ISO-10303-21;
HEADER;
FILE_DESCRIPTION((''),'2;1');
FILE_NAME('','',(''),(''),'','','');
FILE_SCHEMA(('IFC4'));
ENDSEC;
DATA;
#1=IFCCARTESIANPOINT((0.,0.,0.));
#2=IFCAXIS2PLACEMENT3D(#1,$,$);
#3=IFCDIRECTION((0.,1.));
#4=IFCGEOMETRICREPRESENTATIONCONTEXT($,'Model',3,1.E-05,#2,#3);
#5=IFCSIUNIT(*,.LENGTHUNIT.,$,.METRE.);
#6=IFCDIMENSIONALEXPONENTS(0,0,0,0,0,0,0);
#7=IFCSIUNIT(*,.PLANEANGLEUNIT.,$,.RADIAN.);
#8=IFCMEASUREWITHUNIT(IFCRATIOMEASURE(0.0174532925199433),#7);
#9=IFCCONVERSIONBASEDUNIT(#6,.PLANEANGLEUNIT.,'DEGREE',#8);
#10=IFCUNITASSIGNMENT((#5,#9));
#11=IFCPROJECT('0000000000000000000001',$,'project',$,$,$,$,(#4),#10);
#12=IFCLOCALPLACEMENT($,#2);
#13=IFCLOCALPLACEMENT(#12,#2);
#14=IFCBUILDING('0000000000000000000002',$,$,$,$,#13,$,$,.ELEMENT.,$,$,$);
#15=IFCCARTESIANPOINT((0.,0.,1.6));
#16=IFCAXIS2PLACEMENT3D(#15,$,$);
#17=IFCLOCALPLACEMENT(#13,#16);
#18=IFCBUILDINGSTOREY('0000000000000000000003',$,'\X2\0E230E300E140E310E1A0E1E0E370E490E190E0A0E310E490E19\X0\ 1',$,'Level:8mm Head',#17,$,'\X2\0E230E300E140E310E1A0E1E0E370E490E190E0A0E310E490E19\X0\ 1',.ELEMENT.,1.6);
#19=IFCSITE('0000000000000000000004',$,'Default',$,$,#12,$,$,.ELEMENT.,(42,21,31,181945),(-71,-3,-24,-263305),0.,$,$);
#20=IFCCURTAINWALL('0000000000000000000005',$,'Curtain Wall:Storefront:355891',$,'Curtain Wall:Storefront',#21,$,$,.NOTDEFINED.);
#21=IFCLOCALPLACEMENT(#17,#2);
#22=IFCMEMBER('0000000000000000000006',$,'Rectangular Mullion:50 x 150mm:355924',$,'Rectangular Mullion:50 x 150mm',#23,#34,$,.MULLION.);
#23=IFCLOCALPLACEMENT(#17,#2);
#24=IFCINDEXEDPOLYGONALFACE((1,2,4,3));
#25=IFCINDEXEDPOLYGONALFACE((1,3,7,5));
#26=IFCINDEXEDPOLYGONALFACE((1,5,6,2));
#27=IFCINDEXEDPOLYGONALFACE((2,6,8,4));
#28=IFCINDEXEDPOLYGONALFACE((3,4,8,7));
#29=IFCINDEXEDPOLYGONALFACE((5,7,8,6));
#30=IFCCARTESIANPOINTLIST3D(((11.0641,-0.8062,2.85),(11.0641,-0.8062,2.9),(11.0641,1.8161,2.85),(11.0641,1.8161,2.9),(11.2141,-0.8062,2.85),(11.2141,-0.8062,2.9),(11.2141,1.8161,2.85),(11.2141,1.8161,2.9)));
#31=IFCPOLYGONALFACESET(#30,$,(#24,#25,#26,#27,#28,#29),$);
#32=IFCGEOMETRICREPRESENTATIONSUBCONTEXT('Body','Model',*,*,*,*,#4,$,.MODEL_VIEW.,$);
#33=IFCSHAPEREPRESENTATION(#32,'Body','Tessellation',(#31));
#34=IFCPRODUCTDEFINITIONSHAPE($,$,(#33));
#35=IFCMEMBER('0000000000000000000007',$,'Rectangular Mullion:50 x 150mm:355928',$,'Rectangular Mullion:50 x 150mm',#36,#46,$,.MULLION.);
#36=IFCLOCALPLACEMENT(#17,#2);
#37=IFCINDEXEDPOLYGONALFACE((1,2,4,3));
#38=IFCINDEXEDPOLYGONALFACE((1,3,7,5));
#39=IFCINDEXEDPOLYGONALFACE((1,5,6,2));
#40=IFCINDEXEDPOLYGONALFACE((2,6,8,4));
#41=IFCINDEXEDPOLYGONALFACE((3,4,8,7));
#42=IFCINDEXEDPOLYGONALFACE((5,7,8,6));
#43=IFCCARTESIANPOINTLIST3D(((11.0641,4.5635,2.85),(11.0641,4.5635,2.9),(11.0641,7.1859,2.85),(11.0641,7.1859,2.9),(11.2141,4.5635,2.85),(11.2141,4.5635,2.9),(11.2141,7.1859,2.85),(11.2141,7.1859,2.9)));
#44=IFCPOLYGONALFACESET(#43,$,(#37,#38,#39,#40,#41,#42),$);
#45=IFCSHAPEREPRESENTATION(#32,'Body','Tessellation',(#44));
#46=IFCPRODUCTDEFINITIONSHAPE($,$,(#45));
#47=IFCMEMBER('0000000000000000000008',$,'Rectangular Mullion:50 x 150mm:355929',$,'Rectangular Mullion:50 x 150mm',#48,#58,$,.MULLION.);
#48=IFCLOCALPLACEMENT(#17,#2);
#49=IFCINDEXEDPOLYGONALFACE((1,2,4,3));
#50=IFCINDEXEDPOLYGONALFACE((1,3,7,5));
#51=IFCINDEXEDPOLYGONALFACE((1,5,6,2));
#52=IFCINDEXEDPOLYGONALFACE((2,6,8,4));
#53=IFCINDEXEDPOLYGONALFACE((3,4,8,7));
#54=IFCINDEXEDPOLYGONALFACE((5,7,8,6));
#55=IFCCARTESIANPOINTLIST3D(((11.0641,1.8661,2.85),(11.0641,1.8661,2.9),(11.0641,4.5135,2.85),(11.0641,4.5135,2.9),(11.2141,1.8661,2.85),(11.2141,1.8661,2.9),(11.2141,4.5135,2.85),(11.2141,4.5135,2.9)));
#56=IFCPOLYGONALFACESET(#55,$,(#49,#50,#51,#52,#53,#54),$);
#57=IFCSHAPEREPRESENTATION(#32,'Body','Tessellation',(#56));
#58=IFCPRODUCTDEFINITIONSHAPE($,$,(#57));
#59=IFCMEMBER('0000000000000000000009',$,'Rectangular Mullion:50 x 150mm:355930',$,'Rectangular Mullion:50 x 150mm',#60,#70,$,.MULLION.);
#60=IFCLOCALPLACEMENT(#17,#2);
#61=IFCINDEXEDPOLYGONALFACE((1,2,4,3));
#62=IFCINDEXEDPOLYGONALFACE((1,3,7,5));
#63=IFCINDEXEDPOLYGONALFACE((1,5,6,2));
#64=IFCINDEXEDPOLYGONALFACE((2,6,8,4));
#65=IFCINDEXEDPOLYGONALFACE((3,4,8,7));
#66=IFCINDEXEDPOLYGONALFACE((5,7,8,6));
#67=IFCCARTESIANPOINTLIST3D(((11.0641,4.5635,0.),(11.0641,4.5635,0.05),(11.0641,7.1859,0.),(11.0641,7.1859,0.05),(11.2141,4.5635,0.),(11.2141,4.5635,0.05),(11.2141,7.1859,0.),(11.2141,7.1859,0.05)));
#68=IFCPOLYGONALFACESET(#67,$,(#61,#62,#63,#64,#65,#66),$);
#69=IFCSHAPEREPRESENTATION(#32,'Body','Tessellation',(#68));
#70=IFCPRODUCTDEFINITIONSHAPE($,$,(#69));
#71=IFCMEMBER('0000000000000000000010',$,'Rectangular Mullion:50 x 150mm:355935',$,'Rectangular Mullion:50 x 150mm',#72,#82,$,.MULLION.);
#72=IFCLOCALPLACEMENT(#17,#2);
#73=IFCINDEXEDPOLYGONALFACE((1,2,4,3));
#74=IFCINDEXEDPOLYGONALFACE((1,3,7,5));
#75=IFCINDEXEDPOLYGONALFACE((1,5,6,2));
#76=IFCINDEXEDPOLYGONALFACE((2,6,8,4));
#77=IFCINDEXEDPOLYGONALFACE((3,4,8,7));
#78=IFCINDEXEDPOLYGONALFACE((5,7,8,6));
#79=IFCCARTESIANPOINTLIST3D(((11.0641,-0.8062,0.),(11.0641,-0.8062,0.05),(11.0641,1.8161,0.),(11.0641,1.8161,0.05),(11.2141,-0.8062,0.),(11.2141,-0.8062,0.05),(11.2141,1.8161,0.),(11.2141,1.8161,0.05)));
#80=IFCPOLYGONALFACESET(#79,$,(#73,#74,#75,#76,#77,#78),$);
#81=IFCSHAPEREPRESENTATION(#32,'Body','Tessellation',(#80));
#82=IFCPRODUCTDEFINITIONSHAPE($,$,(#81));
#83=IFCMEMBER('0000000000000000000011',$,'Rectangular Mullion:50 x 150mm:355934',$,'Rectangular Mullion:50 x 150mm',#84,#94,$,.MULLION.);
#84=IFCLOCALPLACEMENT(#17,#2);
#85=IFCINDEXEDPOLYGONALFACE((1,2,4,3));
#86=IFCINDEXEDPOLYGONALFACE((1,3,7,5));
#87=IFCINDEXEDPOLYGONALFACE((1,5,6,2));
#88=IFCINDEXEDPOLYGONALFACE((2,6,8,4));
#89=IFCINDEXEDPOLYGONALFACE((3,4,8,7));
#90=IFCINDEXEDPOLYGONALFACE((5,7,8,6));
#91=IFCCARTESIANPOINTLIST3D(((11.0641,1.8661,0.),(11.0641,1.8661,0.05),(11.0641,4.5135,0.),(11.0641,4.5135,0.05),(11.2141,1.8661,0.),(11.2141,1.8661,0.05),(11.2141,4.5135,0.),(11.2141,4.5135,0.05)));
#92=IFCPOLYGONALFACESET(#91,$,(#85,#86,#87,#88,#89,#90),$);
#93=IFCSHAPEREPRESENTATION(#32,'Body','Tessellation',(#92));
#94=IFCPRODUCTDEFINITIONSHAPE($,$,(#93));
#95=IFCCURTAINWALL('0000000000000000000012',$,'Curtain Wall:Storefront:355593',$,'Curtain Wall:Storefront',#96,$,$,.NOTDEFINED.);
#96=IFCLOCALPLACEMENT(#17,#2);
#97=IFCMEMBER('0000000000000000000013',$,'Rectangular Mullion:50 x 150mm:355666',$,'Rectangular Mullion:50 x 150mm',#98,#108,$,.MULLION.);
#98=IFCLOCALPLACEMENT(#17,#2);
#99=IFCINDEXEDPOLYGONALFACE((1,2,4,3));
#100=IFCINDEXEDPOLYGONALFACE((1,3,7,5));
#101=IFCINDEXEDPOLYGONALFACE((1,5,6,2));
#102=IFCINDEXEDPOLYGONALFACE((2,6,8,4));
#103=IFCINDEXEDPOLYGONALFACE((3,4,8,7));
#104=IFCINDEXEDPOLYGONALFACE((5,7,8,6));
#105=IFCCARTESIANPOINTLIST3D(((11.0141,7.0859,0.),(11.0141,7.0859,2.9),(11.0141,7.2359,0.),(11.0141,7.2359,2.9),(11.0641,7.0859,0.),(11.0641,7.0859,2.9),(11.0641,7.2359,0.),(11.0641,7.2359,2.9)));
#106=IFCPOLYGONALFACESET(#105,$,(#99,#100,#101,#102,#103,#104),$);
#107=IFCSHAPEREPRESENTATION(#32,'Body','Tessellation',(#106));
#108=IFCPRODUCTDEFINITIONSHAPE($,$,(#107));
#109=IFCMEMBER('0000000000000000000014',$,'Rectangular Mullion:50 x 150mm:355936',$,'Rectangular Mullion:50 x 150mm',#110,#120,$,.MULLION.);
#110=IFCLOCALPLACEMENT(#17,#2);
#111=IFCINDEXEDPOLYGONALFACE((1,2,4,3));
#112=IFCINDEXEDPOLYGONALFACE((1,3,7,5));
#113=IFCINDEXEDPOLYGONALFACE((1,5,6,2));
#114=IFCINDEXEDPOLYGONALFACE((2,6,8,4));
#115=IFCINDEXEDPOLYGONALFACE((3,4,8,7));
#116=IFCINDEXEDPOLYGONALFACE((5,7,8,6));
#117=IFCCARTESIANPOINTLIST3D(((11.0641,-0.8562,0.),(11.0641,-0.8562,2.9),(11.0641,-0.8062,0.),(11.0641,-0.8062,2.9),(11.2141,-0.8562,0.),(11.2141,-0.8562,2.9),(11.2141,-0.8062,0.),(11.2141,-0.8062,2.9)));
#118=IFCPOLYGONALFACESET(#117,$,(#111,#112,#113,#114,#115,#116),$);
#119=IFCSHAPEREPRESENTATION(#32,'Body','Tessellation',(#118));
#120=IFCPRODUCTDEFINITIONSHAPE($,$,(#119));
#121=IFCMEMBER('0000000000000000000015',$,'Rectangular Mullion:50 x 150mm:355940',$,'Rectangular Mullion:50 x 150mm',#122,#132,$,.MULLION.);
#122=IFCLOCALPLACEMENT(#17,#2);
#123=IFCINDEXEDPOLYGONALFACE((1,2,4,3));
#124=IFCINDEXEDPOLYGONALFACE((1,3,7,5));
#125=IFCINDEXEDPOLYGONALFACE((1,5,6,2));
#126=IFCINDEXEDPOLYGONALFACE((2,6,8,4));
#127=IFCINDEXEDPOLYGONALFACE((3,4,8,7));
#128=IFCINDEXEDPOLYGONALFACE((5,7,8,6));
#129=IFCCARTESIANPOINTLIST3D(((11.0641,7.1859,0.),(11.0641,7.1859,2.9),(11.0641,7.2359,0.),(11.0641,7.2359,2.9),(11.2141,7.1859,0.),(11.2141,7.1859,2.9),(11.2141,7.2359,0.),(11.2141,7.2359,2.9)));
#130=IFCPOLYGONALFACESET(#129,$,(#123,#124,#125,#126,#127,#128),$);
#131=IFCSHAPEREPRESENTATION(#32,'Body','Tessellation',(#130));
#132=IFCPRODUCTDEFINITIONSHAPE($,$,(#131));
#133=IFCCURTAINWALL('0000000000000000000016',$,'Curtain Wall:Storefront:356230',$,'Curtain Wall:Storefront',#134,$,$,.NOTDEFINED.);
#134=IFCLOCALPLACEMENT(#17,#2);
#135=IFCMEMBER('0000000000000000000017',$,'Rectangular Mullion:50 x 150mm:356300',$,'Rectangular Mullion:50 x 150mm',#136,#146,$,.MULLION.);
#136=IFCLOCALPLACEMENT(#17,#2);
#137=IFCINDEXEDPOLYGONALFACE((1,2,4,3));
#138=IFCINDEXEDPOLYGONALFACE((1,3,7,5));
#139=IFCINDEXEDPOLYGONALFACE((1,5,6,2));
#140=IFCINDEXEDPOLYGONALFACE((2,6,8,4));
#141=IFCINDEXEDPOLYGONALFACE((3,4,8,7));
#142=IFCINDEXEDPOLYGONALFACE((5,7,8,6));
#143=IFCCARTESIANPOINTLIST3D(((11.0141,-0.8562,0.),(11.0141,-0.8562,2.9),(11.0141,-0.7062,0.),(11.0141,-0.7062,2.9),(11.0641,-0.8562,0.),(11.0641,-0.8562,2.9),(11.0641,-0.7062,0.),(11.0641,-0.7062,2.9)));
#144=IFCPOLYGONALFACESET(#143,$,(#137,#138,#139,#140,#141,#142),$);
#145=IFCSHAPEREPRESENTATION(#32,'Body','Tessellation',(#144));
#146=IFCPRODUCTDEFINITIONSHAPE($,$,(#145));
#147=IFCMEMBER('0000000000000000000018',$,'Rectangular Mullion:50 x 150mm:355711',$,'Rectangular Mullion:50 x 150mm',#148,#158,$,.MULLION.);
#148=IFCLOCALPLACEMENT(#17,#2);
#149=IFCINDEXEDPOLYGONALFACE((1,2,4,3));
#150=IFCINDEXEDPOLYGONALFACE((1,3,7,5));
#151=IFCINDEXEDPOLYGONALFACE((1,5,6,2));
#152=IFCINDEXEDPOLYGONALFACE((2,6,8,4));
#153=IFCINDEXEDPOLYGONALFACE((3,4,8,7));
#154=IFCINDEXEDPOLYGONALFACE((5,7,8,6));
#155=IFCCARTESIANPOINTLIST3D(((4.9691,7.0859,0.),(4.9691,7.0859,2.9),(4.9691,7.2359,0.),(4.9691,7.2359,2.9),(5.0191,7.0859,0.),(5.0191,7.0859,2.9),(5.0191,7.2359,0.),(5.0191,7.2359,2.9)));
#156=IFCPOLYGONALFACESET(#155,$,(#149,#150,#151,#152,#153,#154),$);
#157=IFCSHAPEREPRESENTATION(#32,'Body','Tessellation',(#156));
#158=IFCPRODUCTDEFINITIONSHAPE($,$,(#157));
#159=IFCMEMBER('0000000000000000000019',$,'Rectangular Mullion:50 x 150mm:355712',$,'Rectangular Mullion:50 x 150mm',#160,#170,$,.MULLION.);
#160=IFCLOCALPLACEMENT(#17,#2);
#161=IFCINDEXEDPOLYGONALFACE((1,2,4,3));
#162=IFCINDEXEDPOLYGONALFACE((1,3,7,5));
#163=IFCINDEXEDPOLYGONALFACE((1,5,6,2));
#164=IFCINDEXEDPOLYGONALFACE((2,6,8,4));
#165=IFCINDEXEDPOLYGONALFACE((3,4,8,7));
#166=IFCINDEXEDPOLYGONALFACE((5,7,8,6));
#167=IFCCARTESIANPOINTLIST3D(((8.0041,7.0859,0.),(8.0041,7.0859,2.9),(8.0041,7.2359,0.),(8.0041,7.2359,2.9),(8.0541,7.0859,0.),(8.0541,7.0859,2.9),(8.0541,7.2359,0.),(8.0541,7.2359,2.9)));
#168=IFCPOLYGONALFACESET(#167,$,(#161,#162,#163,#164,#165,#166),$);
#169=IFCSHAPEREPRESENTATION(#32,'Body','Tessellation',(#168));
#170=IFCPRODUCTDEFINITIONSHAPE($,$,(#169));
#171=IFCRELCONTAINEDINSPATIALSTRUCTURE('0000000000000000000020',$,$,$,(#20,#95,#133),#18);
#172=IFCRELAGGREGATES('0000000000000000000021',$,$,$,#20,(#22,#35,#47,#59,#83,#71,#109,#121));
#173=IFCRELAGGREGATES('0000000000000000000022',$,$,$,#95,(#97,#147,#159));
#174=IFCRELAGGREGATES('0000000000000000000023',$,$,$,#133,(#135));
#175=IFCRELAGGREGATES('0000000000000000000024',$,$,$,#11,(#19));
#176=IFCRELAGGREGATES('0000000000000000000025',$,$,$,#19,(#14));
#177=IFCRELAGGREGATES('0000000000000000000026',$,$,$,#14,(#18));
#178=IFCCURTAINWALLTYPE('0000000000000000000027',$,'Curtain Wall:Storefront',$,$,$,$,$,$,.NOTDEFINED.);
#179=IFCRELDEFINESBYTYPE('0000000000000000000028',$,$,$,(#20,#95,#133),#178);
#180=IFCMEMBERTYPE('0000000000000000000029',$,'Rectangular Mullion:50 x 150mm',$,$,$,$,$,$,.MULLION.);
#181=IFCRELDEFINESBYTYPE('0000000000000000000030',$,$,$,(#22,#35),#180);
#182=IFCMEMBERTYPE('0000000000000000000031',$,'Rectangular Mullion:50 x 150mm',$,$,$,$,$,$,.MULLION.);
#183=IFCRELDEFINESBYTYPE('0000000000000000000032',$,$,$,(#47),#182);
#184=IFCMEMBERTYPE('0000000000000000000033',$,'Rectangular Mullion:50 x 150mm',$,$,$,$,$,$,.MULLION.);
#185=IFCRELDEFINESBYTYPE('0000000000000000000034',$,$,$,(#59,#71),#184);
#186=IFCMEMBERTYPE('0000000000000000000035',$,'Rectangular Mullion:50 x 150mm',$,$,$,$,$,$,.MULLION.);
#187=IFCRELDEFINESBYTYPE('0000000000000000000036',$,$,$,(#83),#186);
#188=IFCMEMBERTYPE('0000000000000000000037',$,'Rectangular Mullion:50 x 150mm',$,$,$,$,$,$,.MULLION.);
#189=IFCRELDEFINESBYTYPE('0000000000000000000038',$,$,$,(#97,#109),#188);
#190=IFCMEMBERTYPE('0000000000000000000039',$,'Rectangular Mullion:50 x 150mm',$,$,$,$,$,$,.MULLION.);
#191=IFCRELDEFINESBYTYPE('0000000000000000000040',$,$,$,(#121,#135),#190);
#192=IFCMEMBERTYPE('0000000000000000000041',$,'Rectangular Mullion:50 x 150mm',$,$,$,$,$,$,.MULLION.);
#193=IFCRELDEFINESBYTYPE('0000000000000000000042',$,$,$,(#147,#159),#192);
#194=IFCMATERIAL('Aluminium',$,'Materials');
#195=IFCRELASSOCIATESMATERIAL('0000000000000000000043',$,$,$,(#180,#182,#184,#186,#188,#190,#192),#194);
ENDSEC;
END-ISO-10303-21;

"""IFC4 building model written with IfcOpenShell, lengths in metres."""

from ifc_helpers import new_model, entity, si_unit, converted_unit, direction, frame, origin, place, context, subcontext, project, spatial, indexed_curve, outline, extrude, source, transform, mapped, material, type_object, type_shapes, element, aggregate, save


model = new_model("IFC4")

# Units and contexts
model_context = context("Model", 3, precision=1e-05, world=origin(), true_north=direction((0.0, 1.0)))
body_context = subcontext(model_context, "Body", "Model", "MODEL_VIEW")
ifc_project = project(units=[si_unit("LENGTHUNIT", "METRE"), converted_unit("PLANEANGLEUNIT", "DEGREE", entity("IfcRatioMeasure", 0.0174532925199433), si_unit("PLANEANGLEUNIT", "RADIAN"), dimensions=[0, 0, 0, 0, 0, 0, 0])], contexts=[model_context])

# Site, building, storey
site_placement = place(None, origin())
site = spatial("IfcSite", under=ifc_project, at=site_placement, Name="Default", CompositionType="ELEMENT", RefLatitude=(42, 21, 31, 181945), RefLongitude=(-71, -3, -24, -263305), RefElevation=0.0)
building_placement = place(site_placement, origin())
building = spatial("IfcBuilding", under=site, at=building_placement, CompositionType="ELEMENT")
storey_placement = place(building_placement, frame((0.0, 0.0, 1.6)))
storey = spatial("IfcBuildingStorey", under=building, at=storey_placement, Name="ระดับพื้นชั้น 1", ObjectType="Level:8mm Head", LongName="ระดับพื้นชั้น 1", CompositionType="ELEMENT", Elevation=1.6)

# Curtain wall, members
curtain_wall_type = type_object("IfcCurtainWallType", Name="Curtain Wall:Storefront", PredefinedType="NOTDEFINED")
curtain_wall_1_placement = place(storey_placement, frame((0.0, 0.0, -1.6)))
curtain_wall_1 = element("IfcCurtainWall", 1, at=curtain_wall_1_placement, inside=storey, type_object=curtain_wall_type, Name="Curtain Wall:Storefront:355891", ObjectType="Curtain Wall:Storefront", PredefinedType="NOTDEFINED")
ifc_material_1 = material(Name="Aluminium", Category="Materials")
member_type_1 = type_object("IfcMemberType", Name="Rectangular Mullion:50 x 150mm", PredefinedType="MULLION", material=ifc_material_1)
shared_shape_1 = source(origin(), body_context, "Body", "SweptSolid", [
    extrude(outline(indexed_curve([(-0.075, -0.025), (0.075, -0.025), (0.075, 0.025), (-0.075, 0.025), (-0.075, -0.025)], self_intersect=False)), frame((-0.025, 0.0, -2.6224), z_axis=(0.0, 0.0, 1.0), x_axis=(0.0, -1.0, 0.0)), (0.0, 0.0, 1.0), 2.6224),
])
type_shapes(member_type_1, [shared_shape_1])
member_1_placement = place(curtain_wall_1_placement, frame((11.1391, -0.8062, 4.5), z_axis=(0.0, -1.0, 0.0), x_axis=(0.0, 0.0, 1.0)))
member_1 = element("IfcMember", 2, at=member_1_placement, type_object=member_type_1, Name="Rectangular Mullion:50 x 150mm:355924", ObjectType="Rectangular Mullion:50 x 150mm", PredefinedType="MULLION", context=body_context, shape_type="MappedRepresentation", body=[
    mapped(shared_shape_1, transform((0.0, 0.0, 0.0), scale=1.0)),
])
member_2_placement = place(curtain_wall_1_placement, frame((11.1391, 4.5635, 4.5), z_axis=(0.0, -1.0, 0.0), x_axis=(0.0, 0.0, 1.0)))
member_2 = element("IfcMember", 3, at=member_2_placement, type_object=member_type_1, Name="Rectangular Mullion:50 x 150mm:355928", ObjectType="Rectangular Mullion:50 x 150mm", PredefinedType="MULLION", context=body_context, shape_type="MappedRepresentation", body=[
    mapped(shared_shape_1, transform((0.0, 0.0, 0.0), scale=1.0)),
])
member_type_2 = type_object("IfcMemberType", Name="Rectangular Mullion:50 x 150mm", PredefinedType="MULLION", material=ifc_material_1)
shared_shape_2 = source(origin(), body_context, "Body", "SweptSolid", [
    extrude(outline(indexed_curve([(-0.075, -0.025), (0.075, -0.025), (0.075, 0.025), (-0.075, 0.025), (-0.075, -0.025)], self_intersect=False)), frame((-0.025, 0.0, -2.6474), z_axis=(0.0, 0.0, 1.0), x_axis=(0.0, -1.0, 0.0)), (0.0, 0.0, 1.0), 2.6474),
])
type_shapes(member_type_2, [shared_shape_2])
member_3_placement = place(curtain_wall_1_placement, frame((11.1391, 1.8661, 4.5), z_axis=(0.0, -1.0, 0.0), x_axis=(0.0, 0.0, 1.0)))
member_3 = element("IfcMember", 4, at=member_3_placement, type_object=member_type_2, Name="Rectangular Mullion:50 x 150mm:355929", ObjectType="Rectangular Mullion:50 x 150mm", PredefinedType="MULLION", context=body_context, shape_type="MappedRepresentation", body=[
    mapped(shared_shape_2, transform((0.0, 0.0, 0.0), scale=1.0)),
])
member_type_3 = type_object("IfcMemberType", Name="Rectangular Mullion:50 x 150mm", PredefinedType="MULLION", material=ifc_material_1)
shared_shape_3 = source(origin(), body_context, "Body", "SweptSolid", [
    extrude(outline(indexed_curve([(-0.075, -0.025), (0.075, -0.025), (0.075, 0.025), (-0.075, 0.025), (-0.075, -0.025)], self_intersect=False)), frame((-0.025, 0.0, -2.6224), z_axis=(0.0, 0.0, 1.0), x_axis=(0.0, -1.0, 0.0)), (0.0, 0.0, 1.0), 2.6224),
])
type_shapes(member_type_3, [shared_shape_3])
member_4_placement = place(curtain_wall_1_placement, frame((11.1391, 7.1859, 1.6), z_axis=(0.0, 1.0, 0.0), x_axis=(0.0, 0.0, -1.0)))
member_4 = element("IfcMember", 5, at=member_4_placement, type_object=member_type_3, Name="Rectangular Mullion:50 x 150mm:355930", ObjectType="Rectangular Mullion:50 x 150mm", PredefinedType="MULLION", context=body_context, shape_type="MappedRepresentation", body=[
    mapped(shared_shape_3, transform((0.0, 0.0, 0.0), scale=1.0)),
])
member_5_placement = place(curtain_wall_1_placement, frame((11.1391, 1.8161, 1.6), z_axis=(0.0, 1.0, 0.0), x_axis=(0.0, 0.0, -1.0)))
member_5 = element("IfcMember", 6, at=member_5_placement, type_object=member_type_3, Name="Rectangular Mullion:50 x 150mm:355935", ObjectType="Rectangular Mullion:50 x 150mm", PredefinedType="MULLION", context=body_context, shape_type="MappedRepresentation", body=[
    mapped(shared_shape_3, transform((0.0, 0.0, 0.0), scale=1.0)),
])
member_type_4 = type_object("IfcMemberType", Name="Rectangular Mullion:50 x 150mm", PredefinedType="MULLION", material=ifc_material_1)
shared_shape_4 = source(origin(), body_context, "Body", "SweptSolid", [
    extrude(outline(indexed_curve([(-0.075, -0.025), (0.075, -0.025), (0.075, 0.025), (-0.075, 0.025), (-0.075, -0.025)], self_intersect=False)), frame((-0.025, 0.0, -2.6474), z_axis=(0.0, 0.0, 1.0), x_axis=(0.0, -1.0, 0.0)), (0.0, 0.0, 1.0), 2.6474),
])
type_shapes(member_type_4, [shared_shape_4])
member_6_placement = place(curtain_wall_1_placement, frame((11.1391, 4.5135, 1.6), z_axis=(0.0, 1.0, 0.0), x_axis=(0.0, 0.0, -1.0)))
member_6 = element("IfcMember", 7, at=member_6_placement, type_object=member_type_4, Name="Rectangular Mullion:50 x 150mm:355934", ObjectType="Rectangular Mullion:50 x 150mm", PredefinedType="MULLION", context=body_context, shape_type="MappedRepresentation", body=[
    mapped(shared_shape_4, transform((0.0, 0.0, 0.0), scale=1.0)),
])

# Curtain wall, member
curtain_wall_2_placement = place(storey_placement, frame((0.0, 0.0, -1.6)))
curtain_wall_2 = element("IfcCurtainWall", 8, at=curtain_wall_2_placement, inside=storey, type_object=curtain_wall_type, Name="Curtain Wall:Storefront:355593", ObjectType="Curtain Wall:Storefront", PredefinedType="NOTDEFINED")
member_type_5 = type_object("IfcMemberType", Name="Rectangular Mullion:50 x 150mm", PredefinedType="MULLION", material=ifc_material_1)
shared_shape_5 = source(origin(), body_context, "Body", "SweptSolid", [
    extrude(outline(indexed_curve([(-0.075, -0.025), (0.075, -0.025), (0.075, 0.025), (-0.075, 0.025), (-0.075, -0.025)], self_intersect=False)), frame((-0.025, 0.0, -2.9), z_axis=(0.0, 0.0, 1.0), x_axis=(0.0, -1.0, 0.0)), (0.0, 0.0, 1.0), 2.9),
])
type_shapes(member_type_5, [shared_shape_5])
member_7_placement = place(curtain_wall_2_placement, frame((11.0641, 7.1609, 1.6), z_axis=(0.0, 0.0, -1.0), x_axis=(1.0, 0.0, 0.0)))
member_7 = element("IfcMember", 9, at=member_7_placement, type_object=member_type_5, Name="Rectangular Mullion:50 x 150mm:355666", ObjectType="Rectangular Mullion:50 x 150mm", PredefinedType="MULLION", context=body_context, shape_type="MappedRepresentation", body=[
    mapped(shared_shape_5, transform((0.0, 0.0, 0.0), scale=1.0)),
])

# Members
member_8_placement = place(curtain_wall_1_placement, frame((11.1391, -0.8562, 1.6), z_axis=(0.0, 0.0, -1.0), x_axis=(0.0, -1.0, 0.0)))
member_8 = element("IfcMember", 10, at=member_8_placement, type_object=member_type_5, Name="Rectangular Mullion:50 x 150mm:355936", ObjectType="Rectangular Mullion:50 x 150mm", PredefinedType="MULLION", context=body_context, shape_type="MappedRepresentation", body=[
    mapped(shared_shape_5, transform((0.0, 0.0, 0.0), scale=1.0)),
])
member_type_6 = type_object("IfcMemberType", Name="Rectangular Mullion:50 x 150mm", PredefinedType="MULLION", material=ifc_material_1)
shared_shape_6 = source(origin(), body_context, "Body", "SweptSolid", [
    extrude(outline(indexed_curve([(-0.075, -0.025), (0.075, -0.025), (0.075, 0.025), (-0.075, 0.025), (-0.075, -0.025)], self_intersect=False)), frame((-0.025, 0.0, -2.9), z_axis=(0.0, 0.0, 1.0), x_axis=(0.0, -1.0, 0.0)), (0.0, 0.0, 1.0), 2.9),
])
type_shapes(member_type_6, [shared_shape_6])
member_9_placement = place(curtain_wall_1_placement, frame((11.1391, 7.2359, 4.5), z_axis=(0.0, 0.0, 1.0), x_axis=(0.0, 1.0, 0.0)))
member_9 = element("IfcMember", 11, at=member_9_placement, type_object=member_type_6, Name="Rectangular Mullion:50 x 150mm:355940", ObjectType="Rectangular Mullion:50 x 150mm", PredefinedType="MULLION", context=body_context, shape_type="MappedRepresentation", body=[
    mapped(shared_shape_6, transform((0.0, 0.0, 0.0), scale=1.0)),
])

# Curtain wall, member
curtain_wall_3_placement = place(storey_placement, frame((0.0, 0.0, -1.6)))
curtain_wall_3 = element("IfcCurtainWall", 12, at=curtain_wall_3_placement, inside=storey, type_object=curtain_wall_type, Name="Curtain Wall:Storefront:356230", ObjectType="Curtain Wall:Storefront", PredefinedType="NOTDEFINED")
member_10_placement = place(curtain_wall_3_placement, frame((11.0641, -0.7812, 4.5)))
member_10 = element("IfcMember", 13, at=member_10_placement, type_object=member_type_6, Name="Rectangular Mullion:50 x 150mm:356300", ObjectType="Rectangular Mullion:50 x 150mm", PredefinedType="MULLION", context=body_context, shape_type="MappedRepresentation", body=[
    mapped(shared_shape_6, transform((0.0, 0.0, 0.0), scale=1.0)),
])

# Members
member_type_7 = type_object("IfcMemberType", Name="Rectangular Mullion:50 x 150mm", PredefinedType="MULLION", material=ifc_material_1)
shared_shape_7 = source(origin(), body_context, "Body", "SweptSolid", [
    extrude(outline(indexed_curve([(-0.075, -0.025), (0.075, -0.025), (0.075, 0.025), (-0.075, 0.025), (-0.075, -0.025)], self_intersect=False)), frame((0.0, 0.0, -2.9), z_axis=(0.0, 0.0, 1.0), x_axis=(0.0, -1.0, 0.0)), (0.0, 0.0, 1.0), 2.9),
])
type_shapes(member_type_7, [shared_shape_7])
member_11_placement = place(curtain_wall_2_placement, frame((4.9941, 7.1609, 1.6), z_axis=(0.0, 0.0, -1.0), x_axis=(1.0, 0.0, 0.0)))
member_11 = element("IfcMember", 14, at=member_11_placement, type_object=member_type_7, Name="Rectangular Mullion:50 x 150mm:355711", ObjectType="Rectangular Mullion:50 x 150mm", PredefinedType="MULLION", context=body_context, shape_type="MappedRepresentation", body=[
    mapped(shared_shape_7, transform((0.0, 0.0, 0.0), scale=1.0)),
])
member_12_placement = place(curtain_wall_2_placement, frame((8.0291, 7.1609, 1.6), z_axis=(0.0, 0.0, -1.0), x_axis=(1.0, 0.0, 0.0)))
member_12 = element("IfcMember", 15, at=member_12_placement, type_object=member_type_7, Name="Rectangular Mullion:50 x 150mm:355712", ObjectType="Rectangular Mullion:50 x 150mm", PredefinedType="MULLION", context=body_context, shape_type="MappedRepresentation", body=[
    mapped(shared_shape_7, transform((0.0, 0.0, 0.0), scale=1.0)),
])

aggregate(curtain_wall_1, [member_1, member_2, member_3, member_4, member_6, member_5, member_8, member_9])
aggregate(curtain_wall_2, [member_7, member_11, member_12])
aggregate(curtain_wall_3, [member_10])

save(model, "model.ifc")
